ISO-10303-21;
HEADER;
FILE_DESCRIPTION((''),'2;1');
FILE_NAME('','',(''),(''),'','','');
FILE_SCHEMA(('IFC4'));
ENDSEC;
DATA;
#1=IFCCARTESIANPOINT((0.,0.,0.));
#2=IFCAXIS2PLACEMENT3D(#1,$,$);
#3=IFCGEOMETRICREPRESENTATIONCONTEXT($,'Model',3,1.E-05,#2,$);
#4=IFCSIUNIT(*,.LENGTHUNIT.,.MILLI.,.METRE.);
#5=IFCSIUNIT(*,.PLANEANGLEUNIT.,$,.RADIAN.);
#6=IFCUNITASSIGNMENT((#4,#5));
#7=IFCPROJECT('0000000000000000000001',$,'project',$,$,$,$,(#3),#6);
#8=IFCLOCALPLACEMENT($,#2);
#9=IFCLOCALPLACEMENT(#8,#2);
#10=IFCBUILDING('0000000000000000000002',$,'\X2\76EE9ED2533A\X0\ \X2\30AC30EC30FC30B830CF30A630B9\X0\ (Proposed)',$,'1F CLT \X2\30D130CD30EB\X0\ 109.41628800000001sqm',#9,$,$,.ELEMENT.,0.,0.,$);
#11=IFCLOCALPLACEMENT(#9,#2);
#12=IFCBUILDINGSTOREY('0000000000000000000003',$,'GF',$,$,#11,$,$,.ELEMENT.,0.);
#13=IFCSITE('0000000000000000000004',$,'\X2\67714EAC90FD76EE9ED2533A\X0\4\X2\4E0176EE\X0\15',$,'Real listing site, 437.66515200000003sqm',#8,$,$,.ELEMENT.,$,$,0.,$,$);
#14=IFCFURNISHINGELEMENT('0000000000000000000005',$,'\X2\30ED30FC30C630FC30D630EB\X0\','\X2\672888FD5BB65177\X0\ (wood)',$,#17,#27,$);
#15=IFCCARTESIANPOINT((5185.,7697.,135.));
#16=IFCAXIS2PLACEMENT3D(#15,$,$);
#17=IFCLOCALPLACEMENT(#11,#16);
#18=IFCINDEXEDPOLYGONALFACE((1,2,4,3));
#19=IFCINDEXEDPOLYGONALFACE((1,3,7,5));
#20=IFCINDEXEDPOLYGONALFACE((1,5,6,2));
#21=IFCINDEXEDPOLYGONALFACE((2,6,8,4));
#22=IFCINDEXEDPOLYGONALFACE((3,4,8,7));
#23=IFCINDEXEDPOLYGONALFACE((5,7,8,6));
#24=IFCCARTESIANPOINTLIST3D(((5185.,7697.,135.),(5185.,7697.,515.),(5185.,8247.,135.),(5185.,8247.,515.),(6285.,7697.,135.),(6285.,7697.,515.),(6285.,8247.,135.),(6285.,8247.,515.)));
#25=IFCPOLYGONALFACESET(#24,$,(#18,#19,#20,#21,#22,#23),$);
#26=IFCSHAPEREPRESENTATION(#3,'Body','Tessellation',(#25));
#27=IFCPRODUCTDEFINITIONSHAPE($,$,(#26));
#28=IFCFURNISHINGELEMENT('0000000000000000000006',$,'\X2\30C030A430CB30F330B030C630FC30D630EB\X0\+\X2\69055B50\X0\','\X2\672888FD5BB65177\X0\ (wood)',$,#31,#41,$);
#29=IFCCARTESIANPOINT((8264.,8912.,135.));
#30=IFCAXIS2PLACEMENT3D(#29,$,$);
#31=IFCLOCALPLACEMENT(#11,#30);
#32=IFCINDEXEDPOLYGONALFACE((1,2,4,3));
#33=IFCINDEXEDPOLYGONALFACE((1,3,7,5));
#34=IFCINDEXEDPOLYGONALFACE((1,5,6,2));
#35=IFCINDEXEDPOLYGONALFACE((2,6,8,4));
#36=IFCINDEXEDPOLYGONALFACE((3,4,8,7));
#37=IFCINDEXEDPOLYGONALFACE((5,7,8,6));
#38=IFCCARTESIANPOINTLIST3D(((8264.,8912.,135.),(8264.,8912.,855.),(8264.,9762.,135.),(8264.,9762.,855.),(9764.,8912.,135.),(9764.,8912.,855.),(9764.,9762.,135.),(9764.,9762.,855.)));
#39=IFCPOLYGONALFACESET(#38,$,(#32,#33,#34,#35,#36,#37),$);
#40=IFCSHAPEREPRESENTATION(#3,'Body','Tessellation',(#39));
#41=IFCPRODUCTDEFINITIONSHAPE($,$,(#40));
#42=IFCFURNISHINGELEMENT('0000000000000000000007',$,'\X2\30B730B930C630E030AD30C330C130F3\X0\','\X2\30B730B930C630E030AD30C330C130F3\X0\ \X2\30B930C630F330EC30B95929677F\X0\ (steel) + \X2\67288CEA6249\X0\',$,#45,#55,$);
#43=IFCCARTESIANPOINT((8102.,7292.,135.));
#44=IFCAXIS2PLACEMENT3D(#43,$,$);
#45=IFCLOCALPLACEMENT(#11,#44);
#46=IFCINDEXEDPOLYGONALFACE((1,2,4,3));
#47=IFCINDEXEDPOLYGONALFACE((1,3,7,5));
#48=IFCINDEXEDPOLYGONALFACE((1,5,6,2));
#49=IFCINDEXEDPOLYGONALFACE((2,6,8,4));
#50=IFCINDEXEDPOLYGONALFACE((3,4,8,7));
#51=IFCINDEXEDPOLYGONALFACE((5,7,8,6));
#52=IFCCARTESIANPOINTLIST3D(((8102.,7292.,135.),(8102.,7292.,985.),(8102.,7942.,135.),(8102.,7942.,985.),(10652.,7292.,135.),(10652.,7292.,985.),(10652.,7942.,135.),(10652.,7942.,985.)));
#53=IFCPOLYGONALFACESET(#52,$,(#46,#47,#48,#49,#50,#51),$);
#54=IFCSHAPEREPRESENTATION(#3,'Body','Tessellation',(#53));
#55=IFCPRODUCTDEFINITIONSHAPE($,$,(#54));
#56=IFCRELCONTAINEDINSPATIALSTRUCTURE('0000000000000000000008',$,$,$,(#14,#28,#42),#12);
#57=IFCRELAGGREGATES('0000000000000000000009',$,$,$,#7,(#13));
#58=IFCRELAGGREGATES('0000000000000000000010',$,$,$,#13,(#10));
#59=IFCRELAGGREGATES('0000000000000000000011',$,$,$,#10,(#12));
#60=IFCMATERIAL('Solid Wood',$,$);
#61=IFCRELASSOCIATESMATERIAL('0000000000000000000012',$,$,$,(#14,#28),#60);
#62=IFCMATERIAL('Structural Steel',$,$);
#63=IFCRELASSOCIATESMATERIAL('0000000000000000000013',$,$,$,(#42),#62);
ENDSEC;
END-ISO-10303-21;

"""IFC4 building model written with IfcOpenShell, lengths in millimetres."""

from ifc_helpers import new_model, si_unit, frame, frame_2d, origin, place, context, project, spatial, rectangle, extrude, material, element, save


model = new_model("IFC4")

# Units and contexts
model_context = context("Model", 3, precision=1e-05, world=origin())
ifc_project = project(units=[si_unit("LENGTHUNIT", "METRE", prefix="MILLI"), si_unit("PLANEANGLEUNIT", "RADIAN")], contexts=[model_context])

# Site, building, storey
site_placement = place(None, origin())
site = spatial("IfcSite", under=ifc_project, at=site_placement, Name="東京都目黒区4丁目15", ObjectType="Real listing site, 437.66515200000003sqm", CompositionType="ELEMENT", RefElevation=0.0)
building_placement = place(site_placement, origin())
building = spatial("IfcBuilding", under=site, at=building_placement, Name="目黒区 ガレージハウス (Proposed)", ObjectType="1F CLT パネル 109.41628800000001sqm", CompositionType="ELEMENT", ElevationOfRefHeight=0.0, ElevationOfTerrain=0.0)
storey_placement = place(building_placement, origin())
storey = spatial("IfcBuildingStorey", under=building, at=storey_placement, Name="GF", CompositionType="ELEMENT", Elevation=0.0)

# Shared definitions
ifc_material_1 = material(Name="Solid Wood")

# Shared definitions
ifc_material_2 = material(Name="Structural Steel")

# Furnishing elements
furnishing_1_placement = place(storey_placement, frame((5185.0, 7697.0, 135.0)))
element("IfcFurnishingElement", 1, at=furnishing_1_placement, inside=storey, material=ifc_material_1, Name="ローテーブル", Description="木製家具 (wood)", context=model_context, shape_type="SweptSolid", body=[
    extrude(rectangle(XDim=1100.0, YDim=550.0, at=frame_2d((550.0, 275.0))), frame((5185.0, 7697.0, 135.0)), (0.0, 0.0, 1.0), 380.0),
])
furnishing_2_placement = place(storey_placement, frame((8264.0, 8912.0, 135.0)))
element("IfcFurnishingElement", 2, at=furnishing_2_placement, inside=storey, material=ifc_material_1, Name="ダイニングテーブル+椅子", Description="木製家具 (wood)", context=model_context, shape_type="SweptSolid", body=[
    extrude(rectangle(XDim=1500.0, YDim=850.0, at=frame_2d((750.0, 425.0))), frame((8264.0, 8912.0, 135.0)), (0.0, 0.0, 1.0), 720.0),
])
furnishing_3_placement = place(storey_placement, frame((8102.0, 7292.0, 135.0)))
element("IfcFurnishingElement", 3, at=furnishing_3_placement, inside=storey, material=ifc_material_2, Name="システムキッチン", Description="システムキッチン ステンレス天板 (steel) + 木質扉", context=model_context, shape_type="SweptSolid", body=[
    extrude(rectangle(XDim=2550.0, YDim=650.0, at=frame_2d((1275.0, 325.0))), frame((8102.0, 7292.0, 135.0)), (0.0, 0.0, 1.0), 850.0),
])

save(model, "model.ifc")
